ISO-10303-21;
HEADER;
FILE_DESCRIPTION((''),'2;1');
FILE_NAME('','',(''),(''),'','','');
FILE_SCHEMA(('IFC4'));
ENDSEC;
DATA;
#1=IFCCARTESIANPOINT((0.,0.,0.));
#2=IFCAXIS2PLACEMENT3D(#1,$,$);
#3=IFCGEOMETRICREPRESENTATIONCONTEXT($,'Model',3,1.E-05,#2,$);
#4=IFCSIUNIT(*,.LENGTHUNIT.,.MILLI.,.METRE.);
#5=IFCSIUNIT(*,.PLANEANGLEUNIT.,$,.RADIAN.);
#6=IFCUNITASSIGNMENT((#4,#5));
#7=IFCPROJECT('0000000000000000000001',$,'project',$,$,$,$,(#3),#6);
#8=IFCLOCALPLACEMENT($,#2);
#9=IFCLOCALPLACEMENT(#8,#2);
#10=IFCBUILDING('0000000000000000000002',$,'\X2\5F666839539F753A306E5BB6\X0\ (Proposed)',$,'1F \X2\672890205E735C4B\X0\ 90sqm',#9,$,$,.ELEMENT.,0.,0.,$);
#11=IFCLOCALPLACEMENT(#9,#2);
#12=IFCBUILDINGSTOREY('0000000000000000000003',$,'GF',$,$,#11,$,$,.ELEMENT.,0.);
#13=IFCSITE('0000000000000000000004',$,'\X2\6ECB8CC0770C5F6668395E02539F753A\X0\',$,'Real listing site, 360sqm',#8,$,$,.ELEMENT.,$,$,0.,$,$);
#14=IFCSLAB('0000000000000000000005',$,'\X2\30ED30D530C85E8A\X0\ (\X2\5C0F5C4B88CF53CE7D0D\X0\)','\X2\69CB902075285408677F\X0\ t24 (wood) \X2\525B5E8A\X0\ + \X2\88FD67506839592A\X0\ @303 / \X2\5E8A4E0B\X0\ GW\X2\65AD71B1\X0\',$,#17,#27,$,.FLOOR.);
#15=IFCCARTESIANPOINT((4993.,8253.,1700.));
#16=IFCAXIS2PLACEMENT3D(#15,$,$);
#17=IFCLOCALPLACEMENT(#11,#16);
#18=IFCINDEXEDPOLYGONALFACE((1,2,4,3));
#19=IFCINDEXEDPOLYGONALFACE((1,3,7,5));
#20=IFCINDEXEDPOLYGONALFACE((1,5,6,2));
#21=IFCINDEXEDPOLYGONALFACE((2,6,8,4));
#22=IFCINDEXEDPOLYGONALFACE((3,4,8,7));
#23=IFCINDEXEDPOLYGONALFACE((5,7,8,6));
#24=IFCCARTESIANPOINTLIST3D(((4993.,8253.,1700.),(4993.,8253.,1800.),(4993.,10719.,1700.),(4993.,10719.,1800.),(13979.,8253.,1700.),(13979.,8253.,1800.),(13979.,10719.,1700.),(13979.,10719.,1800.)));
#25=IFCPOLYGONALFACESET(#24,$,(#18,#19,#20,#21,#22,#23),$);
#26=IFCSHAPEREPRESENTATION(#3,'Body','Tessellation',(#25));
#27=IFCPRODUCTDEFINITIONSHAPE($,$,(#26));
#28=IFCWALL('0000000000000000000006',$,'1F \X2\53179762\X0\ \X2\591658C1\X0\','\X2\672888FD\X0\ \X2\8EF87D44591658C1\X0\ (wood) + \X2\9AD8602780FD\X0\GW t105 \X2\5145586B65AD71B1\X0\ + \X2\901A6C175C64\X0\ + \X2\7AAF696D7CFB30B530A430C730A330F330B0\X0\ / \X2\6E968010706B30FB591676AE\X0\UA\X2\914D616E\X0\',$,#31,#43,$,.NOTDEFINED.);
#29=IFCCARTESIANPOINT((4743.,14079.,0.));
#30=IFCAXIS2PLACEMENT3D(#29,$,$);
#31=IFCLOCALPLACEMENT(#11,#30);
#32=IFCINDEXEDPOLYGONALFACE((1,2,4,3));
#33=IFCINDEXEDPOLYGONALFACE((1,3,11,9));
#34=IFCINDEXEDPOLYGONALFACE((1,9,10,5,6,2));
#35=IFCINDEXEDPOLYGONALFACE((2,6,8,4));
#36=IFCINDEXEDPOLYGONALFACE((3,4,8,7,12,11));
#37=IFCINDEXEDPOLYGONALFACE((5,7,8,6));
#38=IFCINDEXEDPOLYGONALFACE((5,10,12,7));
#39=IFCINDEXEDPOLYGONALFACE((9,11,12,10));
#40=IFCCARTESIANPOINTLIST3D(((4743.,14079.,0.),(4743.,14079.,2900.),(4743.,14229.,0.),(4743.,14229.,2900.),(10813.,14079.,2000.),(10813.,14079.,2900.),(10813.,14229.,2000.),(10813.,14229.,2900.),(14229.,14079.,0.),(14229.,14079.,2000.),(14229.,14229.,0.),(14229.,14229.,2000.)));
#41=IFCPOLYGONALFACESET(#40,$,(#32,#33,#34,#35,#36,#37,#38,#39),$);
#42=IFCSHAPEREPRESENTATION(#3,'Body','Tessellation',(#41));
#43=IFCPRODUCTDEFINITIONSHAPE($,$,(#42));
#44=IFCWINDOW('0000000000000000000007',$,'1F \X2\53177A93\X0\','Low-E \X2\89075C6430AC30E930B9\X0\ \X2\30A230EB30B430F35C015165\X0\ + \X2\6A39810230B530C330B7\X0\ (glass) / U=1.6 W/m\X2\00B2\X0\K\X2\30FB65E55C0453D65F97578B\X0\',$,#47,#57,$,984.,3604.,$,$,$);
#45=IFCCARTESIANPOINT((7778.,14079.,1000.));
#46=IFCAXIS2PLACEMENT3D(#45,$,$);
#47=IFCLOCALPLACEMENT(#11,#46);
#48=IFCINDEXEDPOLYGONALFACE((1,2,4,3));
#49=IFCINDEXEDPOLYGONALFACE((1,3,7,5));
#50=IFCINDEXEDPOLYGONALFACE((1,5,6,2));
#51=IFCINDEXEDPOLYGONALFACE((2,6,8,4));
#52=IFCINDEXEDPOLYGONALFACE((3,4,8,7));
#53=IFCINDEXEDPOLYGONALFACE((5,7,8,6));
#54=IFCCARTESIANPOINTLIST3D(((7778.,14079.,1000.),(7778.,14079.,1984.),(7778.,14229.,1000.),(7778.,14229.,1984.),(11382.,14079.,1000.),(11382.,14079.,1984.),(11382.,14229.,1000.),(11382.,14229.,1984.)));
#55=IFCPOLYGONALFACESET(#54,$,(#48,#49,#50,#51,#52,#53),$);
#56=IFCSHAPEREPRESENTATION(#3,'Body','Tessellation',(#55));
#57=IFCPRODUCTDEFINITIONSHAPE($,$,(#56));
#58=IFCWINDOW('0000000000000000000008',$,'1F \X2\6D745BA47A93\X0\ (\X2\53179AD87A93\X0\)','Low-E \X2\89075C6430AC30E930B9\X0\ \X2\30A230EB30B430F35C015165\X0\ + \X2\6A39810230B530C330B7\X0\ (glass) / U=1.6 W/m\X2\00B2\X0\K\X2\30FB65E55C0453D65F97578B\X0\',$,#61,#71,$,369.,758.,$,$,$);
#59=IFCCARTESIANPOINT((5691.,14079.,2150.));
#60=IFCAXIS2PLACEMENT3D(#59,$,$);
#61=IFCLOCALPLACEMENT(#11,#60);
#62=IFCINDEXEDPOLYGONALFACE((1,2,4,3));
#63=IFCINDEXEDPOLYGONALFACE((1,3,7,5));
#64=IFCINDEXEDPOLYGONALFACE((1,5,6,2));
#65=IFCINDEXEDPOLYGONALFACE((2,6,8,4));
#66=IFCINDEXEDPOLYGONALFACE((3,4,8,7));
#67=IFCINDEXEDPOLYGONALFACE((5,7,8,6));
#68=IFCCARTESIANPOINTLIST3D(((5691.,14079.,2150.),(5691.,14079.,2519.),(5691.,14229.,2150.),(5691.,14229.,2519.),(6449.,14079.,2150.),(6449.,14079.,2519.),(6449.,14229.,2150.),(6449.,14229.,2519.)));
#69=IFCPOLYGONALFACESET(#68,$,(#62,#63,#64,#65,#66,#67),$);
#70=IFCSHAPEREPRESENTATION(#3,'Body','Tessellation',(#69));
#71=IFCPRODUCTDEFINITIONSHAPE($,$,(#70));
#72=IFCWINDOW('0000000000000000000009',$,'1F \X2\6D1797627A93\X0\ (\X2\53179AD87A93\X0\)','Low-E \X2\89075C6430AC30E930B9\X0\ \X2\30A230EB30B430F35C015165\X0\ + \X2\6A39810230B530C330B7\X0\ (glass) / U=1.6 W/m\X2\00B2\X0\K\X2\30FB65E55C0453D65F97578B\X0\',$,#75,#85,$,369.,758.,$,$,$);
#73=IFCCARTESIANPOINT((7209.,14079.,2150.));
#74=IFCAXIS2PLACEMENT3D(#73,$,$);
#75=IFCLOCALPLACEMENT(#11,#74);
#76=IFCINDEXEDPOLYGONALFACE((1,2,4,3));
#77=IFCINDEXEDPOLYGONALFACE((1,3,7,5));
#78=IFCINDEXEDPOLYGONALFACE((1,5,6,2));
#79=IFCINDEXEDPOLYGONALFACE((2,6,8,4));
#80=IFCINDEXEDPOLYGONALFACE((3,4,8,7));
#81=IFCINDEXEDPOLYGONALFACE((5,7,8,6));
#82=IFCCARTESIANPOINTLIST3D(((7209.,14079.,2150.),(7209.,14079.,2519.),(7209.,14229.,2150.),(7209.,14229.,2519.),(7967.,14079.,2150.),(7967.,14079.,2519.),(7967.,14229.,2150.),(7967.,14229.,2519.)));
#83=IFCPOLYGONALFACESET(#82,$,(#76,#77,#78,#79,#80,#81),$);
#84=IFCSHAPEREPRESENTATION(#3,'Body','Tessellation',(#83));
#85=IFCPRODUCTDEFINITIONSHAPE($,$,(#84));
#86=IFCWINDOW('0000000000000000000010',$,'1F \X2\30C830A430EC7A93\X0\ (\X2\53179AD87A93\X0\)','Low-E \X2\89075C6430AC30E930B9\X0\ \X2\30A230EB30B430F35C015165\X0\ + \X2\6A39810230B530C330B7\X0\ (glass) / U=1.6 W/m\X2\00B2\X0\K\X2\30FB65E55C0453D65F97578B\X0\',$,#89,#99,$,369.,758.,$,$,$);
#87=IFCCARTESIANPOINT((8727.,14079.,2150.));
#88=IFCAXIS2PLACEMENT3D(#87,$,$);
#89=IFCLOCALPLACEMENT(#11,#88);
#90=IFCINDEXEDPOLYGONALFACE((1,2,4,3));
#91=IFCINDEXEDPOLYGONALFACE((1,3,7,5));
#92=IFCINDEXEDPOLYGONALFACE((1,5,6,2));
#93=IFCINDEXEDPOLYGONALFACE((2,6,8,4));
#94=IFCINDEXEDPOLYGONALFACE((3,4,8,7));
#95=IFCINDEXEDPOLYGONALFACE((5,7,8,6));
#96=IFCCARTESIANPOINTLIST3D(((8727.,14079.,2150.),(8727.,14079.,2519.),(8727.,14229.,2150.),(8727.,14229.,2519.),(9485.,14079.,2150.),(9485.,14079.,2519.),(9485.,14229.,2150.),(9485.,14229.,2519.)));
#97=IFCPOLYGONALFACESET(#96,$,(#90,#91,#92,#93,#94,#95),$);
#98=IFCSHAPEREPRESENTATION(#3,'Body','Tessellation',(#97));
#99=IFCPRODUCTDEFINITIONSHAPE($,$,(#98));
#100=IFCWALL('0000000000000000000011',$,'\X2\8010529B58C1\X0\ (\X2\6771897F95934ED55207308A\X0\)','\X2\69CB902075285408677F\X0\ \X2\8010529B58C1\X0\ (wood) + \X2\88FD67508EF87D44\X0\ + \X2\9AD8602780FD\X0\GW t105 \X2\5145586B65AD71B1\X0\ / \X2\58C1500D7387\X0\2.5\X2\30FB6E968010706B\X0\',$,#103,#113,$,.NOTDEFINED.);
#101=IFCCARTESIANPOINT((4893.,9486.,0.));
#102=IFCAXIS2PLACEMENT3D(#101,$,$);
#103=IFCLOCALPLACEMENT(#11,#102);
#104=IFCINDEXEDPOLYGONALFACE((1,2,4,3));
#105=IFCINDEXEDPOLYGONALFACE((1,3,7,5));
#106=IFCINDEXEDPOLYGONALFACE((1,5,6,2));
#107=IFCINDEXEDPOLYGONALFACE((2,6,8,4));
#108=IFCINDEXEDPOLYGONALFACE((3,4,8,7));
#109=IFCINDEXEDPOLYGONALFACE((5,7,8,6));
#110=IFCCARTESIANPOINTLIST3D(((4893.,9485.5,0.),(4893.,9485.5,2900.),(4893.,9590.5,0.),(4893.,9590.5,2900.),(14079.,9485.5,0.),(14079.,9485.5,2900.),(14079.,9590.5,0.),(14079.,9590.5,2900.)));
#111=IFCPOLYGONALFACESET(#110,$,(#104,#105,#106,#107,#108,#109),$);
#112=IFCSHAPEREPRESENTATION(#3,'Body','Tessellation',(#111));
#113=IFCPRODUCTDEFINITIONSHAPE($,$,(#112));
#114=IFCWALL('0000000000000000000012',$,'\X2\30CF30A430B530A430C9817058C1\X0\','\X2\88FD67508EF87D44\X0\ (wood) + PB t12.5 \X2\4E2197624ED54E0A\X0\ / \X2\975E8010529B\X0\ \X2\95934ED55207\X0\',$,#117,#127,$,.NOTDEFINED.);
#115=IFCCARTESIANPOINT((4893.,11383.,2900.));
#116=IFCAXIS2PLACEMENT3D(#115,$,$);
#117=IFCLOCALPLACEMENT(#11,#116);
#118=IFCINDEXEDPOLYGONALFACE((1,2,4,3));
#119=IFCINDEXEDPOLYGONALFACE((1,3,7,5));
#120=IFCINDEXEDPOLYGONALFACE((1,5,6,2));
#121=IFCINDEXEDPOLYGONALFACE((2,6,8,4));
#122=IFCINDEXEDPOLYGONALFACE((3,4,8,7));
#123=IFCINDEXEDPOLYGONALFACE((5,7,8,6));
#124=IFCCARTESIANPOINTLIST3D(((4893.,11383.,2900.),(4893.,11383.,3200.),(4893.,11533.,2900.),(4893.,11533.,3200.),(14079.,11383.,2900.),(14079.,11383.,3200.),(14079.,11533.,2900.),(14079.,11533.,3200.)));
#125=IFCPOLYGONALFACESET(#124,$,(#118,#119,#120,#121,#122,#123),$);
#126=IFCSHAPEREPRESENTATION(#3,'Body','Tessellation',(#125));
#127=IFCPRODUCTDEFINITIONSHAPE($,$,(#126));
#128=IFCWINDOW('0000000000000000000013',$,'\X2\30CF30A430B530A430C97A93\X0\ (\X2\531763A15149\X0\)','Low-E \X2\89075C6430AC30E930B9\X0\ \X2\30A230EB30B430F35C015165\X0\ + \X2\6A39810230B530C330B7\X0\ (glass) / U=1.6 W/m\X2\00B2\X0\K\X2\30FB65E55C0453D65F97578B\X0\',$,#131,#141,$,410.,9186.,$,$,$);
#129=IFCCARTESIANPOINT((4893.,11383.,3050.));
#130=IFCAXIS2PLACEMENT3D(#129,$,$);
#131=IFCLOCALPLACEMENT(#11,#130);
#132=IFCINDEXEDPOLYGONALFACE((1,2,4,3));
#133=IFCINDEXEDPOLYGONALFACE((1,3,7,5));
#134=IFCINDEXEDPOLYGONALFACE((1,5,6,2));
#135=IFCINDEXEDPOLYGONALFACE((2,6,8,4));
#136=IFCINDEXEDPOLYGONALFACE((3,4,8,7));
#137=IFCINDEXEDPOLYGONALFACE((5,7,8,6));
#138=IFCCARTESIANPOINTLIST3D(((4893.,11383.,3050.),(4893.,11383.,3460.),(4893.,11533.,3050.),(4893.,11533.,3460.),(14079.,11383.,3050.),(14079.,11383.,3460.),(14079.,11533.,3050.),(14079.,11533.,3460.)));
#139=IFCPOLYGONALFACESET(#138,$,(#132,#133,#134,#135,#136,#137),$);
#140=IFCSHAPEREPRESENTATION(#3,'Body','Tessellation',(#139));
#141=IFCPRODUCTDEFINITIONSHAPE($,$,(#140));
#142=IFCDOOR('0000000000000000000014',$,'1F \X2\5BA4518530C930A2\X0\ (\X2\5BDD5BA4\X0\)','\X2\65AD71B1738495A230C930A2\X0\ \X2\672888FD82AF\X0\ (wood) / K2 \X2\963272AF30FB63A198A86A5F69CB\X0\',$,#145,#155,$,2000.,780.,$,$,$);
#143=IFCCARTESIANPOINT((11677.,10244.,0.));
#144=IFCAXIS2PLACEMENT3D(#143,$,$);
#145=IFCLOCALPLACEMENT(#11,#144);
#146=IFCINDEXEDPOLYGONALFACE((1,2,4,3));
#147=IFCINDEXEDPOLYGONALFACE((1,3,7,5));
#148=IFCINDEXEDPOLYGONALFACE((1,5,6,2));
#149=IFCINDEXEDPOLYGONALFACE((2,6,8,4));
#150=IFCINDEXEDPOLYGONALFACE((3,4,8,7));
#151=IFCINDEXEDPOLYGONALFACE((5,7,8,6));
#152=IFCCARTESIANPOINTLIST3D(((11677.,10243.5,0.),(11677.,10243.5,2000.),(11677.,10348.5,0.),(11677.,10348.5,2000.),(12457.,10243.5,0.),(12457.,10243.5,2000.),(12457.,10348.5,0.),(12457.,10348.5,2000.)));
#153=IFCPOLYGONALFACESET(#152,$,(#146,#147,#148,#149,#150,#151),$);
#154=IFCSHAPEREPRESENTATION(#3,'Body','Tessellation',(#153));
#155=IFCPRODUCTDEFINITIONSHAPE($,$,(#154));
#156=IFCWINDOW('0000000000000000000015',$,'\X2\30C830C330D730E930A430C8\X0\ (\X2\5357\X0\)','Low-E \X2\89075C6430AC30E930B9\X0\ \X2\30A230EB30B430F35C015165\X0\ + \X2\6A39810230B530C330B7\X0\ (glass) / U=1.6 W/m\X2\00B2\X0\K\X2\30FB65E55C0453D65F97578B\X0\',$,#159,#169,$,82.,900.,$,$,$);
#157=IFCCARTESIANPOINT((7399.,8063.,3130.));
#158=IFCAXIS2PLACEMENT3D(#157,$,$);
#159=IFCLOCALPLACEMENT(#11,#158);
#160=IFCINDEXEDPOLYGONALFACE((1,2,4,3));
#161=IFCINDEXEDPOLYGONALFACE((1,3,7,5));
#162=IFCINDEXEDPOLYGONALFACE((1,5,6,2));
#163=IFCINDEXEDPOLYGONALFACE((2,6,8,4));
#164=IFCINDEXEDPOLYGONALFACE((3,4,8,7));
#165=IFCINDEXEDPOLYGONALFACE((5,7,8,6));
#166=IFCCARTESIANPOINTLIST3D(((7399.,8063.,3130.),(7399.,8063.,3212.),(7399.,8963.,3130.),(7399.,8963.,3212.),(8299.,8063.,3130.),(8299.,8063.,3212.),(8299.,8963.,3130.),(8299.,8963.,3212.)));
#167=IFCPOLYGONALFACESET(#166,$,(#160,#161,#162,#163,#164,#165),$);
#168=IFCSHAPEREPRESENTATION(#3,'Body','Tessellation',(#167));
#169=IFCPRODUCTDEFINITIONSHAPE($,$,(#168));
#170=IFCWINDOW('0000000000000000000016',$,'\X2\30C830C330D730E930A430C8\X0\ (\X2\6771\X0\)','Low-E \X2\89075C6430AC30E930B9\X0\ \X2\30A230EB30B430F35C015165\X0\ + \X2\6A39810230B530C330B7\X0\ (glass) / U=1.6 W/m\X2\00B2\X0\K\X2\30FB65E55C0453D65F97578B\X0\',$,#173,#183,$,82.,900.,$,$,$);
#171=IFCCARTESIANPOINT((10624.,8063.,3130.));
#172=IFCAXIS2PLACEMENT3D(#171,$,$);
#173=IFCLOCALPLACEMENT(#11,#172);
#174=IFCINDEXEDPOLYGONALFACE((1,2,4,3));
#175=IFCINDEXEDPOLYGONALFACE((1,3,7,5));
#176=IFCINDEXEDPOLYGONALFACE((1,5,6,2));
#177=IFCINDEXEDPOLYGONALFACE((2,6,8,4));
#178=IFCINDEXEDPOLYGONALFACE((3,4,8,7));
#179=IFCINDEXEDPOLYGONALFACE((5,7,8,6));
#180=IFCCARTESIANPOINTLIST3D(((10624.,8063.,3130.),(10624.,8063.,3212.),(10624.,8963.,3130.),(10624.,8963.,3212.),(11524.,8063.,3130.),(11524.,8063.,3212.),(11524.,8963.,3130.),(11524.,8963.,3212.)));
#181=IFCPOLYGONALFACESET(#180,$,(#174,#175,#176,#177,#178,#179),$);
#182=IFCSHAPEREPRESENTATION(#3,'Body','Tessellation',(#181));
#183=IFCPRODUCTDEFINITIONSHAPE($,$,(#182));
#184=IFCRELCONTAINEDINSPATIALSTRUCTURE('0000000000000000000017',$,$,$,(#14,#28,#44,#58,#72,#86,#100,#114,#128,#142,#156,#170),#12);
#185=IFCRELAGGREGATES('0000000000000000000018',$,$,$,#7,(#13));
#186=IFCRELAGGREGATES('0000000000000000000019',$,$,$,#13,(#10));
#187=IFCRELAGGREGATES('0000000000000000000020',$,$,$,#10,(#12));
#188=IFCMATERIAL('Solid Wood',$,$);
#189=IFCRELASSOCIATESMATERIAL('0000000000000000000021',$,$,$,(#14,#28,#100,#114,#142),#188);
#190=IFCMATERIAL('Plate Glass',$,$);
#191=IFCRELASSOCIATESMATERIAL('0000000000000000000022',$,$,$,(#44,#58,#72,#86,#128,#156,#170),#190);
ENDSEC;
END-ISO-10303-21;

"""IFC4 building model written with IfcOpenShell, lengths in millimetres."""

from ifc_helpers import new_model, si_unit, frame, frame_2d, origin, place, context, project, spatial, rectangle, extrude, material, element, fill, save


model = new_model("IFC4")

# Units and contexts
model_context = context("Model", 3, precision=1e-05, world=origin())
ifc_project = project(units=[si_unit("LENGTHUNIT", "METRE", prefix="MILLI"), si_unit("PLANEANGLEUNIT", "RADIAN")], contexts=[model_context])

# Site, building, storey
site_placement = place(None, origin())
site = spatial("IfcSite", under=ifc_project, at=site_placement, Name="滋賀県彦根市原町", ObjectType="Real listing site, 360sqm", CompositionType="ELEMENT", RefElevation=0.0)
building_placement = place(site_placement, origin())
building = spatial("IfcBuilding", under=site, at=building_placement, Name="彦根原町の家 (Proposed)", ObjectType="1F 木造平屋 90sqm", CompositionType="ELEMENT", ElevationOfRefHeight=0.0, ElevationOfTerrain=0.0)
storey_placement = place(building_placement, origin())
storey = spatial("IfcBuildingStorey", under=building, at=storey_placement, Name="GF", CompositionType="ELEMENT", Elevation=0.0)

# Slab
ifc_material_1 = material(Name="Solid Wood")
slab_placement = place(storey_placement, frame((4993.0, 8253.0, 1700.0)))
element("IfcSlab", 1, at=slab_placement, inside=storey, material=ifc_material_1, Name="ロフト床 (小屋裏収納)", Description="構造用合板 t24 (wood) 剛床 + 製材根太 @303 / 床下 GW断熱", PredefinedType="FLOOR", context=model_context, shape_type="SweptSolid", body=[
    extrude(rectangle(XDim=8986.0, YDim=2466.0, at=frame_2d((4493.0, 1233.0))), frame((4993.0, 8253.0, 1700.0)), (0.0, 0.0, 1.0), 100.0),
])

# Wall, openings, windows
wall_1_placement = place(storey_placement, frame((4743.0, 14079.0, 0.0)))
wall_1 = element("IfcWall", 2, at=wall_1_placement, inside=storey, material=ifc_material_1, Name="1F 北面 外壁", Description="木製 軸組外壁 (wood) + 高性能GW t105 充填断熱 + 通気層 + 窯業系サイディング / 準耐火・外皮UA配慮", PredefinedType="NOTDEFINED", context=model_context, shape_type="SweptSolid", body=[
    extrude(rectangle(XDim=9486.0, YDim=150.0, at=frame_2d((4743.0, 75.0))), frame((4743.0, 14079.0, 0.0)), (0.0, 0.0, 1.0), 2900.0),
])
opening_1_placement = place(storey_placement, frame((7778.0, 14079.0, 1000.0)))
opening_1 = element("IfcOpeningElement", 3, at=opening_1_placement, cuts=wall_1, PredefinedType="NOTDEFINED", context=model_context, shape_type="SweptSolid", body=[
    extrude(rectangle(XDim=3604.0, YDim=150.0, at=frame_2d((1802.0, 75.0))), frame((7778.0, 14079.0, 1000.0)), (0.0, 0.0, 1.0), 984.0),
])
opening_2_placement = place(storey_placement, frame((5691.0, 14079.0, 2150.0)))
opening_2 = element("IfcOpeningElement", 4, at=opening_2_placement, cuts=wall_1, PredefinedType="NOTDEFINED", context=model_context, shape_type="SweptSolid", body=[
    extrude(rectangle(XDim=758.0, YDim=150.0, at=frame_2d((379.0, 75.0))), frame((5691.0, 14079.0, 2150.0)), (0.0, 0.0, 1.0), 369.0),
])
opening_3_placement = place(storey_placement, frame((7209.0, 14079.0, 2150.0)))
opening_3 = element("IfcOpeningElement", 5, at=opening_3_placement, cuts=wall_1, PredefinedType="NOTDEFINED", context=model_context, shape_type="SweptSolid", body=[
    extrude(rectangle(XDim=758.0, YDim=150.0, at=frame_2d((379.0, 75.0))), frame((7209.0, 14079.0, 2150.0)), (0.0, 0.0, 1.0), 369.0),
])
opening_4_placement = place(storey_placement, frame((8727.0, 14079.0, 2150.0)))
opening_4 = element("IfcOpeningElement", 6, at=opening_4_placement, cuts=wall_1, PredefinedType="NOTDEFINED", context=model_context, shape_type="SweptSolid", body=[
    extrude(rectangle(XDim=758.0, YDim=150.0, at=frame_2d((379.0, 75.0))), frame((8727.0, 14079.0, 2150.0)), (0.0, 0.0, 1.0), 369.0),
])
ifc_material_2 = material(Name="Plate Glass")
window_1_placement = place(storey_placement, frame((7778.0, 14079.0, 1000.0)))
window_1 = element("IfcWindow", 7, at=window_1_placement, inside=storey, material=ifc_material_2, Name="1F 北窓", Description="Low-E 複層ガラス アルゴン封入 + 樹脂サッシ (glass) / U=1.6 W/m²K・日射取得型", OverallHeight=984.0, OverallWidth=3604.0, context=model_context, shape_type="SweptSolid", body=[
    extrude(rectangle(XDim=3604.0, YDim=150.0, at=frame_2d((1802.0, 75.0))), frame((7778.0, 14079.0, 1000.0)), (0.0, 0.0, 1.0), 984.0),
])
fill(opening_1, window_1)
window_2_placement = place(storey_placement, frame((5691.0, 14079.0, 2150.0)))
window_2 = element("IfcWindow", 8, at=window_2_placement, inside=storey, material=ifc_material_2, Name="1F 浴室窓 (北高窓)", Description="Low-E 複層ガラス アルゴン封入 + 樹脂サッシ (glass) / U=1.6 W/m²K・日射取得型", OverallHeight=369.0, OverallWidth=758.0, context=model_context, shape_type="SweptSolid", body=[
    extrude(rectangle(XDim=758.0, YDim=150.0, at=frame_2d((379.0, 75.0))), frame((5691.0, 14079.0, 2150.0)), (0.0, 0.0, 1.0), 369.0),
])
fill(opening_2, window_2)
window_3_placement = place(storey_placement, frame((7209.0, 14079.0, 2150.0)))
window_3 = element("IfcWindow", 9, at=window_3_placement, inside=storey, material=ifc_material_2, Name="1F 洗面窓 (北高窓)", Description="Low-E 複層ガラス アルゴン封入 + 樹脂サッシ (glass) / U=1.6 W/m²K・日射取得型", OverallHeight=369.0, OverallWidth=758.0, context=model_context, shape_type="SweptSolid", body=[
    extrude(rectangle(XDim=758.0, YDim=150.0, at=frame_2d((379.0, 75.0))), frame((7209.0, 14079.0, 2150.0)), (0.0, 0.0, 1.0), 369.0),
])
fill(opening_3, window_3)
window_4_placement = place(storey_placement, frame((8727.0, 14079.0, 2150.0)))
window_4 = element("IfcWindow", 10, at=window_4_placement, inside=storey, material=ifc_material_2, Name="1F トイレ窓 (北高窓)", Description="Low-E 複層ガラス アルゴン封入 + 樹脂サッシ (glass) / U=1.6 W/m²K・日射取得型", OverallHeight=369.0, OverallWidth=758.0, context=model_context, shape_type="SweptSolid", body=[
    extrude(rectangle(XDim=758.0, YDim=150.0, at=frame_2d((379.0, 75.0))), frame((8727.0, 14079.0, 2150.0)), (0.0, 0.0, 1.0), 369.0),
])
fill(opening_4, window_4)

# Wall
wall_2_placement = place(storey_placement, frame((4893.0, 9486.0, 0.0)))
element("IfcWall", 11, at=wall_2_placement, inside=storey, material=ifc_material_1, Name="耐力壁 (東西間仕切り)", Description="構造用合板 耐力壁 (wood) + 製材軸組 + 高性能GW t105 充填断熱 / 壁倍率2.5・準耐火", PredefinedType="NOTDEFINED", context=model_context, shape_type="SweptSolid", body=[
    extrude(rectangle(XDim=9186.0, YDim=105.0, at=frame_2d((4593.0, 52.0))), frame((4893.0, 9486.0, 0.0)), (0.0, 0.0, 1.0), 2900.0),
])

# Wall, opening, window
wall_3_placement = place(storey_placement, frame((4893.0, 11383.0, 2900.0)))
wall_3 = element("IfcWall", 12, at=wall_3_placement, inside=storey, material=ifc_material_1, Name="ハイサイド腰壁", Description="製材軸組 (wood) + PB t12.5 両面仕上 / 非耐力 間仕切", PredefinedType="NOTDEFINED", context=model_context, shape_type="SweptSolid", body=[
    extrude(rectangle(XDim=9186.0, YDim=150.0, at=frame_2d((4593.0, 75.0))), frame((4893.0, 11383.0, 2900.0)), (0.0, 0.0, 1.0), 700.0),
])
opening_5_placement = place(storey_placement, frame((4893.0, 11383.0, 3050.0)))
opening_5 = element("IfcOpeningElement", 13, at=opening_5_placement, cuts=wall_3, PredefinedType="NOTDEFINED", context=model_context, shape_type="SweptSolid", body=[
    extrude(rectangle(XDim=9186.0, YDim=150.0, at=frame_2d((4593.0, 75.0))), frame((4893.0, 11383.0, 3050.0)), (0.0, 0.0, 1.0), 410.0),
])
window_5_placement = place(storey_placement, frame((4893.0, 11383.0, 3050.0)))
window_5 = element("IfcWindow", 14, at=window_5_placement, inside=storey, material=ifc_material_2, Name="ハイサイド窓 (北採光)", Description="Low-E 複層ガラス アルゴン封入 + 樹脂サッシ (glass) / U=1.6 W/m²K・日射取得型", OverallHeight=410.0, OverallWidth=9186.0, context=model_context, shape_type="SweptSolid", body=[
    extrude(rectangle(XDim=9186.0, YDim=150.0, at=frame_2d((4593.0, 75.0))), frame((4893.0, 11383.0, 3050.0)), (0.0, 0.0, 1.0), 410.0),
])
fill(opening_5, window_5)

# Door
door_1_placement = place(storey_placement, frame((11677.0, 10244.0, 0.0)))
element("IfcDoor", 15, at=door_1_placement, inside=storey, material=ifc_material_1, Name="1F 室内ドア (寝室)", Description="断熱玄関ドア 木製芯 (wood) / K2 防犯・採風機構", OverallHeight=2000.0, OverallWidth=780.0, context=model_context, shape_type="SweptSolid", body=[
    extrude(rectangle(XDim=780.0, YDim=105.0, at=frame_2d((390.0, 52.0))), frame((11677.0, 10244.0, 0.0)), (0.0, 0.0, 1.0), 2000.0),
])

# Windows
window_6_placement = place(storey_placement, frame((7399.0, 8063.0, 3130.0)))
element("IfcWindow", 16, at=window_6_placement, inside=storey, material=ifc_material_2, Name="トップライト (南)", Description="Low-E 複層ガラス アルゴン封入 + 樹脂サッシ (glass) / U=1.6 W/m²K・日射取得型", OverallHeight=82.0, OverallWidth=900.0, context=model_context, shape_type="SweptSolid", body=[
    extrude(rectangle(XDim=900.0, YDim=900.0, at=frame_2d((450.0, 450.0))), frame((7399.0, 8063.0, 3130.0)), (0.0, 0.0, 1.0), 82.0),
])
window_7_placement = place(storey_placement, frame((10624.0, 8063.0, 3130.0)))
element("IfcWindow", 17, at=window_7_placement, inside=storey, material=ifc_material_2, Name="トップライト (東)", Description="Low-E 複層ガラス アルゴン封入 + 樹脂サッシ (glass) / U=1.6 W/m²K・日射取得型", OverallHeight=82.0, OverallWidth=900.0, context=model_context, shape_type="SweptSolid", body=[
    extrude(rectangle(XDim=900.0, YDim=900.0, at=frame_2d((450.0, 450.0))), frame((10624.0, 8063.0, 3130.0)), (0.0, 0.0, 1.0), 82.0),
])

save(model, "model.ifc")
